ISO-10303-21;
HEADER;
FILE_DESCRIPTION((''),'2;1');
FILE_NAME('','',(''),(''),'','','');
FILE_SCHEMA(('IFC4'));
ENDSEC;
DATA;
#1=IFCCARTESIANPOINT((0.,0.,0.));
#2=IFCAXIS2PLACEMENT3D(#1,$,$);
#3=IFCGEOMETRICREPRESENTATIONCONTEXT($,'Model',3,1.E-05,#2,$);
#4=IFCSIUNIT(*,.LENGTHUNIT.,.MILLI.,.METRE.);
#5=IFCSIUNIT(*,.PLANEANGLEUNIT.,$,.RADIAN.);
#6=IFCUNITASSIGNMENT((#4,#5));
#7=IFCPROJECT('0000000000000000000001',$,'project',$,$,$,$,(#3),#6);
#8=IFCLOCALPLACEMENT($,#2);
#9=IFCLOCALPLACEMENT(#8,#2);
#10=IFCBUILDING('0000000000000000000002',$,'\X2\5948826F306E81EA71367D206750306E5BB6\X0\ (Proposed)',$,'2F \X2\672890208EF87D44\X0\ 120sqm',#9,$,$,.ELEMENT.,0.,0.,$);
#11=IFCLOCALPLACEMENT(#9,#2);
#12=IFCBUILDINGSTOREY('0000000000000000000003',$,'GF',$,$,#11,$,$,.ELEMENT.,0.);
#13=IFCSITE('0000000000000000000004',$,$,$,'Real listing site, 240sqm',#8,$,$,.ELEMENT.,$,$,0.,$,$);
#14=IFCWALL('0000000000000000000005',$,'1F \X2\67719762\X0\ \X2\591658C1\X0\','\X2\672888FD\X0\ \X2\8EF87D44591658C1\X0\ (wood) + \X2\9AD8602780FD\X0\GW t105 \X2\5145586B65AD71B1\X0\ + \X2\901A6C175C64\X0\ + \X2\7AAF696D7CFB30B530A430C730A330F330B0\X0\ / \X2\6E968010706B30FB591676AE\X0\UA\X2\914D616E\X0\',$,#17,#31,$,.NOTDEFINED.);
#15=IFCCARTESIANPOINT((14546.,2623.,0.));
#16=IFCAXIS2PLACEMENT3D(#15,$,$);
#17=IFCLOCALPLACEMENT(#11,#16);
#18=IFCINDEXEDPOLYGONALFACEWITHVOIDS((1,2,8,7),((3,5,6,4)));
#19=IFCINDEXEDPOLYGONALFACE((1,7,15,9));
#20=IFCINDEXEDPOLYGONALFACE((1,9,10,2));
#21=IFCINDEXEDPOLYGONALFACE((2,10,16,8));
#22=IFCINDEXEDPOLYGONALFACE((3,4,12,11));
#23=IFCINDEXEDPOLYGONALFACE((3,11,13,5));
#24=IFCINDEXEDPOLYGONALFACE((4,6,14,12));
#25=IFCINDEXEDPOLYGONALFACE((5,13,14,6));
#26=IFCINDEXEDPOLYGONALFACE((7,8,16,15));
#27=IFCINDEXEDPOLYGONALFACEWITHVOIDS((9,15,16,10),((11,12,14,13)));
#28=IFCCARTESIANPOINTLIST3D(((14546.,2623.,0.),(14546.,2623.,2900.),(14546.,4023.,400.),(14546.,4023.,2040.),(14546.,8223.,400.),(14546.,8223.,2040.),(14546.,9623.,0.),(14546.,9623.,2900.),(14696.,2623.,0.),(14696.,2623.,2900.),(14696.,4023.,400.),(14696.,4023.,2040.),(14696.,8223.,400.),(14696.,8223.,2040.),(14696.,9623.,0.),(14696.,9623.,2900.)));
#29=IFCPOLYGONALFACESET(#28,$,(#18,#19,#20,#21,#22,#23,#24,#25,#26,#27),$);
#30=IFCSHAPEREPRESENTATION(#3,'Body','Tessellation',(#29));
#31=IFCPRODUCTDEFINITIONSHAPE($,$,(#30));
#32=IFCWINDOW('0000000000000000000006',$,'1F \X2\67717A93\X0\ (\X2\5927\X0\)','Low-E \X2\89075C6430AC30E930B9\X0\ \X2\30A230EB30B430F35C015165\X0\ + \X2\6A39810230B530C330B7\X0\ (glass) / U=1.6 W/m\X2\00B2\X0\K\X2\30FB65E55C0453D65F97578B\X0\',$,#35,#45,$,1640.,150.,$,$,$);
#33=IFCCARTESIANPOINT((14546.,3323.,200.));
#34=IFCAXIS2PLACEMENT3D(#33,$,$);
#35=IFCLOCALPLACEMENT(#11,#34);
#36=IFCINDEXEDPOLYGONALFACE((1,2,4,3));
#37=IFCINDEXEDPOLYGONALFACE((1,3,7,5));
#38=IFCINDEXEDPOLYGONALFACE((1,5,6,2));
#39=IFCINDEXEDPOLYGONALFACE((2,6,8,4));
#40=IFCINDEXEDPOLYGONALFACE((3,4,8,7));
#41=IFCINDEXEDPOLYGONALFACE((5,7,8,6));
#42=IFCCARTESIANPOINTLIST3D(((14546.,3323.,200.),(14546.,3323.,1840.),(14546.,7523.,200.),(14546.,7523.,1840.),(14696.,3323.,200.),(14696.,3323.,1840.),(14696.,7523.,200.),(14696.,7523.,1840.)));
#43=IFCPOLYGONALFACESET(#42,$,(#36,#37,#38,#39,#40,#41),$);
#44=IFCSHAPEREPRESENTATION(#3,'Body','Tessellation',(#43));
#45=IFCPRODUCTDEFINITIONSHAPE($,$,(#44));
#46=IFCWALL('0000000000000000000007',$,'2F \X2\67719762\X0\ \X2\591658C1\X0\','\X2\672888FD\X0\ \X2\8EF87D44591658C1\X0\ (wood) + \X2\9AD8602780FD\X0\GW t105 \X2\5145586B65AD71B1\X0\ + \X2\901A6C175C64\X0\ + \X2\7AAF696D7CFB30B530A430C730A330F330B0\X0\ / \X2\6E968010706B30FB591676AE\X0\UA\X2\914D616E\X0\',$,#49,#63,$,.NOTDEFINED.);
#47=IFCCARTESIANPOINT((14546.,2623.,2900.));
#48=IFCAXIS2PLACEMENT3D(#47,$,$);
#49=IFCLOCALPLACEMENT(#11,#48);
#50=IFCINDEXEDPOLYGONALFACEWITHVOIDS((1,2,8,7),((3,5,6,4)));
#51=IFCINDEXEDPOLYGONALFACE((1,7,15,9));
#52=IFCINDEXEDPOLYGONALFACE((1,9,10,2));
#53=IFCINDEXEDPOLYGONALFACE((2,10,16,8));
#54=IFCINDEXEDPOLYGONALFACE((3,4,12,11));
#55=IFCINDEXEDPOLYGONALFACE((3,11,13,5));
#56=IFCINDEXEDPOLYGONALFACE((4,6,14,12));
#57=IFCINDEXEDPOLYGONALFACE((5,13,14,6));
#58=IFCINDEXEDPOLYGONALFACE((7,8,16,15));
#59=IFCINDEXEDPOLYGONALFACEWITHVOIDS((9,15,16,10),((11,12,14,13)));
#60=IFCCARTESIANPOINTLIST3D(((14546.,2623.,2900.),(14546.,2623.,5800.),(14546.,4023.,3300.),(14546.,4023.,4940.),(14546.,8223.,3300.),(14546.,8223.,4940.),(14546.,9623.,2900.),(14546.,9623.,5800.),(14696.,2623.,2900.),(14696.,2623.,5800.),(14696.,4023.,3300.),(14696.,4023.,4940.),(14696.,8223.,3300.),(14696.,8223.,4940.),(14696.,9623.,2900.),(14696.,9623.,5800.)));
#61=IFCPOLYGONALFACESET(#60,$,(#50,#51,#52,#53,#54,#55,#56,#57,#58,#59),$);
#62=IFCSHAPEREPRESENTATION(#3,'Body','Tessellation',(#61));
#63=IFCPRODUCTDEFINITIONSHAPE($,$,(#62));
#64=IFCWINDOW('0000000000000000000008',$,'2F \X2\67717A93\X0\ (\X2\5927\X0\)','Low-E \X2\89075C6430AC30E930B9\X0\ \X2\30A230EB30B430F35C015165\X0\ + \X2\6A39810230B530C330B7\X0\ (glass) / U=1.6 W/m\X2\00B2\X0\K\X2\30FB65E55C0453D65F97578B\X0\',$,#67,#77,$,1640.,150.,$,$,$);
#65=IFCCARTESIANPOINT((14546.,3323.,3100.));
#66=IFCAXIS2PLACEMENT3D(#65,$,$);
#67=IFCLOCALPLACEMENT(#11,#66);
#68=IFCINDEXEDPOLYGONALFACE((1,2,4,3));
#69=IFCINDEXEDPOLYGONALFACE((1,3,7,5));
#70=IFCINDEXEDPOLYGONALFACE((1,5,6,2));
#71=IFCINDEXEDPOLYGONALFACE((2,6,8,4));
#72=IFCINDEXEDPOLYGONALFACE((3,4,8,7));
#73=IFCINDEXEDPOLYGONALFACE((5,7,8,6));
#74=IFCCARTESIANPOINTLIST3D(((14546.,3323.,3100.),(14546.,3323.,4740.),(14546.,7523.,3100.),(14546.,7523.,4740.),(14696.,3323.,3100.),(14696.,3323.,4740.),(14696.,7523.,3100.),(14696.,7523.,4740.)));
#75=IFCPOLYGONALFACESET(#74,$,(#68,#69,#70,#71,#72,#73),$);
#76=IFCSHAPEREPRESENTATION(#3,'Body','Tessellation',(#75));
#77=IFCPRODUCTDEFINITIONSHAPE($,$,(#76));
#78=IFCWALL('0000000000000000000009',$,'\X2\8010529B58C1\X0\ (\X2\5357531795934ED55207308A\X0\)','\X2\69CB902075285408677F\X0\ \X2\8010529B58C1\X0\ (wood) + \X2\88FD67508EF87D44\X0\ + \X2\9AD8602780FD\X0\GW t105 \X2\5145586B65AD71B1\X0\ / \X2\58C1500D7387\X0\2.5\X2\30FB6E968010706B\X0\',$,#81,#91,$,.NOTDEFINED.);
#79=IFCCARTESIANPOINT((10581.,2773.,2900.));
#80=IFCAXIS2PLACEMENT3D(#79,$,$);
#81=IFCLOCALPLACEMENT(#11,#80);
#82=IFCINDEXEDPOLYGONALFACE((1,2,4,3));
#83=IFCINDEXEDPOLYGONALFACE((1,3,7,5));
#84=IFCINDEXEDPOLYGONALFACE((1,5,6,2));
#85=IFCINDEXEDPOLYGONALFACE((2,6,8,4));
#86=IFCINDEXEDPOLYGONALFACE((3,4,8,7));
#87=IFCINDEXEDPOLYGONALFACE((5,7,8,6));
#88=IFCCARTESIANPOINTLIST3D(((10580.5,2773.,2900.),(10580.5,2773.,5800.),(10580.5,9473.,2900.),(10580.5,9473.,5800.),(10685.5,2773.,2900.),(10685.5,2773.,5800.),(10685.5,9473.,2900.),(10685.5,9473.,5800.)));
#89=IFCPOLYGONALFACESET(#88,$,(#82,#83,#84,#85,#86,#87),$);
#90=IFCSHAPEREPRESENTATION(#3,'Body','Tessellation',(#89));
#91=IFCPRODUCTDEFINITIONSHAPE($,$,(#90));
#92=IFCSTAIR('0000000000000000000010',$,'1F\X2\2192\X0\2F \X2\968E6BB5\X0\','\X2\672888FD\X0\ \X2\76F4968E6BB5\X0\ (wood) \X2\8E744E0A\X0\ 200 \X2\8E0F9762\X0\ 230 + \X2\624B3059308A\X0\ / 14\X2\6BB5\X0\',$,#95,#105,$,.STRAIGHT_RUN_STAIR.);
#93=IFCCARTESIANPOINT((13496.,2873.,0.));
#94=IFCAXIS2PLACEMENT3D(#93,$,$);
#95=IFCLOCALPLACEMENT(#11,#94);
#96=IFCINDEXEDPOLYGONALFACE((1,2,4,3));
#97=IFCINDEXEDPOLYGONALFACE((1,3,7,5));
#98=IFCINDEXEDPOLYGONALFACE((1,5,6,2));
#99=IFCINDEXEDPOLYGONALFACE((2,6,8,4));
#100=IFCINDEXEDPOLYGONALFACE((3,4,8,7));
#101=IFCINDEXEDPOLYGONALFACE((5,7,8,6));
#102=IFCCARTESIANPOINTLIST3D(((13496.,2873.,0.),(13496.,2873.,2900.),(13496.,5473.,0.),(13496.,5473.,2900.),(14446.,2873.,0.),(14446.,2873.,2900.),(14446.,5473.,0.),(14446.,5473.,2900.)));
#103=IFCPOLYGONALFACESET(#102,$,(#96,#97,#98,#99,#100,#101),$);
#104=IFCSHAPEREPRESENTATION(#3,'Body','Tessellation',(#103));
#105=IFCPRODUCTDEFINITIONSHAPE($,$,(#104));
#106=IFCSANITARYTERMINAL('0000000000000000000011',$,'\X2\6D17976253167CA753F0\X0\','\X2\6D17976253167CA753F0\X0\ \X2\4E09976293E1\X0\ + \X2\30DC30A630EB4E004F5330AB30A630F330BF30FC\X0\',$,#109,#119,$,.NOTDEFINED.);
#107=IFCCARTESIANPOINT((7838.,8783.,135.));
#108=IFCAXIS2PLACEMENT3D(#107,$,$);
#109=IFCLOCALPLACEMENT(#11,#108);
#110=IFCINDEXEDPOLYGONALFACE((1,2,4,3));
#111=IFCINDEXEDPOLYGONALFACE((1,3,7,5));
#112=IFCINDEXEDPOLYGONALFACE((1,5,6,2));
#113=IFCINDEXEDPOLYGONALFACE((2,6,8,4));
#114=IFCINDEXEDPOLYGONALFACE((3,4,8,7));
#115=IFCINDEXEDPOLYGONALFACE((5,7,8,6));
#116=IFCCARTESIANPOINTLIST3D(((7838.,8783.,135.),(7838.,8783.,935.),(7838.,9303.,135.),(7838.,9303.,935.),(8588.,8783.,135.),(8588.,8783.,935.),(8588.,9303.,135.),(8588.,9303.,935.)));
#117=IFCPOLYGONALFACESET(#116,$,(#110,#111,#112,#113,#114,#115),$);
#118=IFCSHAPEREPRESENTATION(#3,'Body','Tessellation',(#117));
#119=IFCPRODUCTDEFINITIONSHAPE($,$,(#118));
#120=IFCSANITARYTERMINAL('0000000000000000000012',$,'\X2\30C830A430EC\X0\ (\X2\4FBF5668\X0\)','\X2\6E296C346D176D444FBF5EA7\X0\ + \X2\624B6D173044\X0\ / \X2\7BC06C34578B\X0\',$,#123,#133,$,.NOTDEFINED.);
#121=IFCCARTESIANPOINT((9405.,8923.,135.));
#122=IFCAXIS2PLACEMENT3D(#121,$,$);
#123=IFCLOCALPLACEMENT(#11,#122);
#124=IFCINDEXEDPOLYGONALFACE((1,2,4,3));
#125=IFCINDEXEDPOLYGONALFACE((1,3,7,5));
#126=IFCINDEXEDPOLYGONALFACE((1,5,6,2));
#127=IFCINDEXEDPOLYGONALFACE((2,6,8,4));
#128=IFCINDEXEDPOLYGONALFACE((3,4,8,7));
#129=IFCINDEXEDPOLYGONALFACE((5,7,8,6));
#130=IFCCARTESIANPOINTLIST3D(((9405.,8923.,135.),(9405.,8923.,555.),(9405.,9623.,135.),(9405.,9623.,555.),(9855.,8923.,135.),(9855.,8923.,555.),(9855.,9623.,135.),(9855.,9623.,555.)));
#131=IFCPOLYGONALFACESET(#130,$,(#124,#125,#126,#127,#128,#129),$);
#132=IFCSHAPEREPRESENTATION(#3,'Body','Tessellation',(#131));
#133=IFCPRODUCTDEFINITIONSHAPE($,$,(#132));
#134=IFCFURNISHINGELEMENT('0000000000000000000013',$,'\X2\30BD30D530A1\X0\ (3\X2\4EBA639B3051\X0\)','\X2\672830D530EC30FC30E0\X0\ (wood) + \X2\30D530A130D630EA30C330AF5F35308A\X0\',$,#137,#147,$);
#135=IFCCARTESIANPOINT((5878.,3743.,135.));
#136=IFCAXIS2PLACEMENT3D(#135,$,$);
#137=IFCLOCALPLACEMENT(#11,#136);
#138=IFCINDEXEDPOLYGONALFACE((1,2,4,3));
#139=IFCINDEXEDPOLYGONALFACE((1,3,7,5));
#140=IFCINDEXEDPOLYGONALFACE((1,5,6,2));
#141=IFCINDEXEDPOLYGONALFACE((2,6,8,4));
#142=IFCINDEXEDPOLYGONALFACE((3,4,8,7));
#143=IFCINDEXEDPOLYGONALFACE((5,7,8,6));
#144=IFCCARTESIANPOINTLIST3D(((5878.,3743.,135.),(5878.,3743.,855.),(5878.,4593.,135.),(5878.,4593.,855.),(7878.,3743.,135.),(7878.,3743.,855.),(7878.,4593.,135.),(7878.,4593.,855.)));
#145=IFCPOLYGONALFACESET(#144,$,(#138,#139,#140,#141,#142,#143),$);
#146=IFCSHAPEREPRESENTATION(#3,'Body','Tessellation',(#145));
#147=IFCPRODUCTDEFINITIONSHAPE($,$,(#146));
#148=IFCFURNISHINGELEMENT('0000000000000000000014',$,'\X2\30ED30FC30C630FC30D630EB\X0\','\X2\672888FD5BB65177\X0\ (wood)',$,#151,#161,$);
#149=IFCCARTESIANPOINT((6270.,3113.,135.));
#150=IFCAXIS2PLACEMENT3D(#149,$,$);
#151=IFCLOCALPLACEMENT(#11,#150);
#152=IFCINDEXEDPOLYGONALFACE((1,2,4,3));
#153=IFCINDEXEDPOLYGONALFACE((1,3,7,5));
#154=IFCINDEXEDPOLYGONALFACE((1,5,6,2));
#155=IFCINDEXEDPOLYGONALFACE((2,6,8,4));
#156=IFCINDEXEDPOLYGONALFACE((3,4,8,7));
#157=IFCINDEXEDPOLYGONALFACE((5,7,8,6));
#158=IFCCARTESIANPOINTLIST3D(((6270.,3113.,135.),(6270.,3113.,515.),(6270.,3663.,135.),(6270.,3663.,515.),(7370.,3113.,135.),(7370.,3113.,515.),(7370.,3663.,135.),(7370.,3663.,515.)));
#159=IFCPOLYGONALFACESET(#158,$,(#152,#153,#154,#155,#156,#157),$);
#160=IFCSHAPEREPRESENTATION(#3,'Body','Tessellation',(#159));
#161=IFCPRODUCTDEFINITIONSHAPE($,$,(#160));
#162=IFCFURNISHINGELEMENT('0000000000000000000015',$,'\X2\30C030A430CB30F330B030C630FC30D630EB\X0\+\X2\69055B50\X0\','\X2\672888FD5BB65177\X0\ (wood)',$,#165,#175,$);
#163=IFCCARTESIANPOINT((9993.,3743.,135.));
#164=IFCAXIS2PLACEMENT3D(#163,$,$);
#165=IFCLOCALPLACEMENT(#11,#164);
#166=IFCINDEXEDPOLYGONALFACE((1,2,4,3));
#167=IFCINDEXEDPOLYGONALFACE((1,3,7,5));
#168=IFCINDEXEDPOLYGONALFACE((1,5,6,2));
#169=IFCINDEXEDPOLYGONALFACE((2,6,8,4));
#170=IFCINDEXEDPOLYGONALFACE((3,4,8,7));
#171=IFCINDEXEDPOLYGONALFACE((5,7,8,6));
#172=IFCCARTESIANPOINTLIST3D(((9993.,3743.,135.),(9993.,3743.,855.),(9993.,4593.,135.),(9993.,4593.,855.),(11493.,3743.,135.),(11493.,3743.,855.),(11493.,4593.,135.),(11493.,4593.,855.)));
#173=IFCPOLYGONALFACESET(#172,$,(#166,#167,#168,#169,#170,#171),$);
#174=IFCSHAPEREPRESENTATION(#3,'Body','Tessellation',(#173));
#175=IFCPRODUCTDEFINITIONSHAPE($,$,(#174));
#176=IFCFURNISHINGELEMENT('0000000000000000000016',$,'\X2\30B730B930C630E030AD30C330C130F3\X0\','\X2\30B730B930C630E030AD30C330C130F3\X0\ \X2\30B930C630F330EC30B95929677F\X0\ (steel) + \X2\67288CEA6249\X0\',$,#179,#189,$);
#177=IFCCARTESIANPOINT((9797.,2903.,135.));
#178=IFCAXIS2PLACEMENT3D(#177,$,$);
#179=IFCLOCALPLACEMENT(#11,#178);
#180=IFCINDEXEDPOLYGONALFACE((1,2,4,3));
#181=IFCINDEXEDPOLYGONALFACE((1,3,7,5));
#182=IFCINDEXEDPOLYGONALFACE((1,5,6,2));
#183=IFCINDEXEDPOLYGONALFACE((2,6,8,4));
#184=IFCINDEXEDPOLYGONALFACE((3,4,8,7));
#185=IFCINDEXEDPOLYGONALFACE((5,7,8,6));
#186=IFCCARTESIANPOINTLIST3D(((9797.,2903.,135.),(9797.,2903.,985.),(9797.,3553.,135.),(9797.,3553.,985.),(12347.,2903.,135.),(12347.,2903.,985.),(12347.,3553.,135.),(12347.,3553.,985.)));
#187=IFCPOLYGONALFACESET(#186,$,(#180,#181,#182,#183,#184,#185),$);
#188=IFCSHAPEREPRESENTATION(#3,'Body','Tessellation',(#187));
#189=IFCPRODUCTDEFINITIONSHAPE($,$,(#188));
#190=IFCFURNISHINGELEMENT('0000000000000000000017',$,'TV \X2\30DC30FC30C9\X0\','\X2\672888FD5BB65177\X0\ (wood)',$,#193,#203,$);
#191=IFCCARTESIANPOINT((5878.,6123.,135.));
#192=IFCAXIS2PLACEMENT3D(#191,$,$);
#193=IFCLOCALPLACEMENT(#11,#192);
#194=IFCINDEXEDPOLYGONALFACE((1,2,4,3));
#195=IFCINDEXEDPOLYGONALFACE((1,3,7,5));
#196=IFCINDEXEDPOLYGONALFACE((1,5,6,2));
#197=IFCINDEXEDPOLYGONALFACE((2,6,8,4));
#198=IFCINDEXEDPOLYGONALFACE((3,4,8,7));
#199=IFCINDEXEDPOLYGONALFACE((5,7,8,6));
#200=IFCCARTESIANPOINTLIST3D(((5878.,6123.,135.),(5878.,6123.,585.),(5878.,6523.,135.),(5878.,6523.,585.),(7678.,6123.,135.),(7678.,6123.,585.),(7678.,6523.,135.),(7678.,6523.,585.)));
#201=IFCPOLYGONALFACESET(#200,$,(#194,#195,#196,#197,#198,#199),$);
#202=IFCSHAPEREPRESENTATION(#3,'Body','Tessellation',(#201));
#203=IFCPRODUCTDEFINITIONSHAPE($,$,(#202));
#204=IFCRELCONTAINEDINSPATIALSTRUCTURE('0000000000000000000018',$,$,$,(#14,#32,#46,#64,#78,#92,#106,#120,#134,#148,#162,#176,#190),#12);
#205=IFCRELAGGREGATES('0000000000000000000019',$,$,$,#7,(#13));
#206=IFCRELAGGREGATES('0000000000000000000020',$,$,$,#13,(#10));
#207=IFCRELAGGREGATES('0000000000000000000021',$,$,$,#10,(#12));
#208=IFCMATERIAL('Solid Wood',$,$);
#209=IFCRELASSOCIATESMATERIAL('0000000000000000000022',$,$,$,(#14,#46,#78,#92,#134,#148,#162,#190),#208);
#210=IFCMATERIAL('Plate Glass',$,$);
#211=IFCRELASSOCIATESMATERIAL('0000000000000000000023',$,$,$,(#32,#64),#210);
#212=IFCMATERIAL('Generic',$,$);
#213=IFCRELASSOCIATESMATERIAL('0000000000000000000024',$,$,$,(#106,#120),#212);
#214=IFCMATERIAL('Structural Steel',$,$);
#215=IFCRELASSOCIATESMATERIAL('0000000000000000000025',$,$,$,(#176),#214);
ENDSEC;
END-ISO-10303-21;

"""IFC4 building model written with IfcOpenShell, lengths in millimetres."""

from ifc_helpers import new_model, si_unit, frame, frame_2d, origin, place, context, project, spatial, rectangle, extrude, material, element, fill, save


model = new_model("IFC4")

# Units and contexts
model_context = context("Model", 3, precision=1e-05, world=origin())
ifc_project = project(units=[si_unit("LENGTHUNIT", "METRE", prefix="MILLI"), si_unit("PLANEANGLEUNIT", "RADIAN")], contexts=[model_context])

# Site, building, storey
site_placement = place(None, origin())
site = spatial("IfcSite", under=ifc_project, at=site_placement, ObjectType="Real listing site, 240sqm", CompositionType="ELEMENT", RefElevation=0.0)
building_placement = place(site_placement, origin())
building = spatial("IfcBuilding", under=site, at=building_placement, Name="奈良の自然素材の家 (Proposed)", ObjectType="2F 木造軸組 120sqm", CompositionType="ELEMENT", ElevationOfRefHeight=0.0, ElevationOfTerrain=0.0)
storey_placement = place(building_placement, origin())
storey = spatial("IfcBuildingStorey", under=building, at=storey_placement, Name="GF", CompositionType="ELEMENT", Elevation=0.0)

# Shared definitions
ifc_material_1 = material(Name="Solid Wood")

# Wall, opening, window
wall_1_placement = place(storey_placement, frame((14546.0, 2623.0, 0.0)))
wall_1 = element("IfcWall", 1, at=wall_1_placement, inside=storey, material=ifc_material_1, Name="1F 東面 外壁", Description="木製 軸組外壁 (wood) + 高性能GW t105 充填断熱 + 通気層 + 窯業系サイディング / 準耐火・外皮UA配慮", PredefinedType="NOTDEFINED", context=model_context, shape_type="SweptSolid", body=[
    extrude(rectangle(XDim=150.0, YDim=7000.0, at=frame_2d((75.0, 3500.0))), frame((14546.0, 2623.0, 0.0)), (0.0, 0.0, 1.0), 2900.0),
])
opening_1_placement = place(storey_placement, frame((14546.0, 3323.0, 200.0)))
opening_1 = element("IfcOpeningElement", 2, at=opening_1_placement, cuts=wall_1, PredefinedType="NOTDEFINED", context=model_context, shape_type="SweptSolid", body=[
    extrude(rectangle(XDim=150.0, YDim=4200.0, at=frame_2d((75.0, 2100.0))), frame((14546.0, 3323.0, 200.0)), (0.0, 0.0, 1.0), 1640.0),
])
ifc_material_2 = material(Name="Plate Glass")
window_1_placement = place(storey_placement, frame((14546.0, 3323.0, 200.0)))
window_1 = element("IfcWindow", 3, at=window_1_placement, inside=storey, material=ifc_material_2, Name="1F 東窓 (大)", Description="Low-E 複層ガラス アルゴン封入 + 樹脂サッシ (glass) / U=1.6 W/m²K・日射取得型", OverallHeight=1640.0, OverallWidth=150.0, context=model_context, shape_type="SweptSolid", body=[
    extrude(rectangle(XDim=150.0, YDim=4200.0, at=frame_2d((75.0, 2100.0))), frame((14546.0, 3323.0, 200.0)), (0.0, 0.0, 1.0), 1640.0),
])
fill(opening_1, window_1)

# Wall, opening, window
wall_2_placement = place(storey_placement, frame((14546.0, 2623.0, 2900.0)))
wall_2 = element("IfcWall", 4, at=wall_2_placement, inside=storey, material=ifc_material_1, Name="2F 東面 外壁", Description="木製 軸組外壁 (wood) + 高性能GW t105 充填断熱 + 通気層 + 窯業系サイディング / 準耐火・外皮UA配慮", PredefinedType="NOTDEFINED", context=model_context, shape_type="SweptSolid", body=[
    extrude(rectangle(XDim=150.0, YDim=7000.0, at=frame_2d((75.0, 3500.0))), frame((14546.0, 2623.0, 2900.0)), (0.0, 0.0, 1.0), 2900.0),
])
opening_2_placement = place(storey_placement, frame((14546.0, 3323.0, 3100.0)))
opening_2 = element("IfcOpeningElement", 5, at=opening_2_placement, cuts=wall_2, PredefinedType="NOTDEFINED", context=model_context, shape_type="SweptSolid", body=[
    extrude(rectangle(XDim=150.0, YDim=4200.0, at=frame_2d((75.0, 2100.0))), frame((14546.0, 3323.0, 3100.0)), (0.0, 0.0, 1.0), 1640.0),
])
window_2_placement = place(storey_placement, frame((14546.0, 3323.0, 3100.0)))
window_2 = element("IfcWindow", 6, at=window_2_placement, inside=storey, material=ifc_material_2, Name="2F 東窓 (大)", Description="Low-E 複層ガラス アルゴン封入 + 樹脂サッシ (glass) / U=1.6 W/m²K・日射取得型", OverallHeight=1640.0, OverallWidth=150.0, context=model_context, shape_type="SweptSolid", body=[
    extrude(rectangle(XDim=150.0, YDim=4200.0, at=frame_2d((75.0, 2100.0))), frame((14546.0, 3323.0, 3100.0)), (0.0, 0.0, 1.0), 1640.0),
])
fill(opening_2, window_2)

# Wall
wall_3_placement = place(storey_placement, frame((10581.0, 2773.0, 2900.0)))
element("IfcWall", 7, at=wall_3_placement, inside=storey, material=ifc_material_1, Name="耐力壁 (南北間仕切り)", Description="構造用合板 耐力壁 (wood) + 製材軸組 + 高性能GW t105 充填断熱 / 壁倍率2.5・準耐火", PredefinedType="NOTDEFINED", context=model_context, shape_type="SweptSolid", body=[
    extrude(rectangle(XDim=105.0, YDim=6700.0, at=frame_2d((52.0, 3350.0))), frame((10581.0, 2773.0, 2900.0)), (0.0, 0.0, 1.0), 2900.0),
])

# Stair
stair_placement = place(storey_placement, frame((13496.0, 2873.0, 0.0)))
element("IfcStair", 8, at=stair_placement, inside=storey, material=ifc_material_1, Name="1F→2F 階段", Description="木製 直階段 (wood) 蹴上 200 踏面 230 + 手すり / 14段", PredefinedType="STRAIGHT_RUN_STAIR", context=model_context, shape_type="SweptSolid", body=[
    extrude(rectangle(XDim=950.0, YDim=2600.0, at=frame_2d((475.0, 1300.0))), frame((13496.0, 2873.0, 0.0)), (0.0, 0.0, 1.0), 2900.0),
])

# Sanitary terminals
ifc_material_3 = material(Name="Generic")
sanitary_terminal_1_placement = place(storey_placement, frame((7838.0, 8783.0, 135.0)))
element("IfcSanitaryTerminal", 9, at=sanitary_terminal_1_placement, inside=storey, material=ifc_material_3, Name="洗面化粧台", Description="洗面化粧台 三面鏡 + ボウル一体カウンター", PredefinedType="NOTDEFINED", context=model_context, shape_type="SweptSolid", body=[
    extrude(rectangle(XDim=750.0, YDim=520.0, at=frame_2d((375.0, 260.0))), frame((7838.0, 8783.0, 135.0)), (0.0, 0.0, 1.0), 800.0),
])
sanitary_terminal_2_placement = place(storey_placement, frame((9405.0, 8923.0, 135.0)))
element("IfcSanitaryTerminal", 10, at=sanitary_terminal_2_placement, inside=storey, material=ifc_material_3, Name="トイレ (便器)", Description="温水洗浄便座 + 手洗い / 節水型", PredefinedType="NOTDEFINED", context=model_context, shape_type="SweptSolid", body=[
    extrude(rectangle(XDim=450.0, YDim=700.0, at=frame_2d((225.0, 350.0))), frame((9405.0, 8923.0, 135.0)), (0.0, 0.0, 1.0), 420.0),
])

# Furnishing elements
furnishing_1_placement = place(storey_placement, frame((5878.0, 3743.0, 135.0)))
element("IfcFurnishingElement", 11, at=furnishing_1_placement, inside=storey, material=ifc_material_1, Name="ソファ (3人掛け)", Description="木フレーム (wood) + ファブリック張り", context=model_context, shape_type="SweptSolid", body=[
    extrude(rectangle(XDim=2000.0, YDim=850.0, at=frame_2d((1000.0, 425.0))), frame((5878.0, 3743.0, 135.0)), (0.0, 0.0, 1.0), 720.0),
])
furnishing_2_placement = place(storey_placement, frame((6270.0, 3113.0, 135.0)))
element("IfcFurnishingElement", 12, at=furnishing_2_placement, inside=storey, material=ifc_material_1, Name="ローテーブル", Description="木製家具 (wood)", context=model_context, shape_type="SweptSolid", body=[
    extrude(rectangle(XDim=1100.0, YDim=550.0, at=frame_2d((550.0, 275.0))), frame((6270.0, 3113.0, 135.0)), (0.0, 0.0, 1.0), 380.0),
])
furnishing_3_placement = place(storey_placement, frame((9993.0, 3743.0, 135.0)))
element("IfcFurnishingElement", 13, at=furnishing_3_placement, inside=storey, material=ifc_material_1, Name="ダイニングテーブル+椅子", Description="木製家具 (wood)", context=model_context, shape_type="SweptSolid", body=[
    extrude(rectangle(XDim=1500.0, YDim=850.0, at=frame_2d((750.0, 425.0))), frame((9993.0, 3743.0, 135.0)), (0.0, 0.0, 1.0), 720.0),
])
ifc_material_4 = material(Name="Structural Steel")
furnishing_4_placement = place(storey_placement, frame((9797.0, 2903.0, 135.0)))
element("IfcFurnishingElement", 14, at=furnishing_4_placement, inside=storey, material=ifc_material_4, Name="システムキッチン", Description="システムキッチン ステンレス天板 (steel) + 木質扉", context=model_context, shape_type="SweptSolid", body=[
    extrude(rectangle(XDim=2550.0, YDim=650.0, at=frame_2d((1275.0, 325.0))), frame((9797.0, 2903.0, 135.0)), (0.0, 0.0, 1.0), 850.0),
])
furnishing_5_placement = place(storey_placement, frame((5878.0, 6123.0, 135.0)))
element("IfcFurnishingElement", 15, at=furnishing_5_placement, inside=storey, material=ifc_material_1, Name="TV ボード", Description="木製家具 (wood)", context=model_context, shape_type="SweptSolid", body=[
    extrude(rectangle(XDim=1800.0, YDim=400.0, at=frame_2d((900.0, 200.0))), frame((5878.0, 6123.0, 135.0)), (0.0, 0.0, 1.0), 450.0),
])

save(model, "model.ifc")
